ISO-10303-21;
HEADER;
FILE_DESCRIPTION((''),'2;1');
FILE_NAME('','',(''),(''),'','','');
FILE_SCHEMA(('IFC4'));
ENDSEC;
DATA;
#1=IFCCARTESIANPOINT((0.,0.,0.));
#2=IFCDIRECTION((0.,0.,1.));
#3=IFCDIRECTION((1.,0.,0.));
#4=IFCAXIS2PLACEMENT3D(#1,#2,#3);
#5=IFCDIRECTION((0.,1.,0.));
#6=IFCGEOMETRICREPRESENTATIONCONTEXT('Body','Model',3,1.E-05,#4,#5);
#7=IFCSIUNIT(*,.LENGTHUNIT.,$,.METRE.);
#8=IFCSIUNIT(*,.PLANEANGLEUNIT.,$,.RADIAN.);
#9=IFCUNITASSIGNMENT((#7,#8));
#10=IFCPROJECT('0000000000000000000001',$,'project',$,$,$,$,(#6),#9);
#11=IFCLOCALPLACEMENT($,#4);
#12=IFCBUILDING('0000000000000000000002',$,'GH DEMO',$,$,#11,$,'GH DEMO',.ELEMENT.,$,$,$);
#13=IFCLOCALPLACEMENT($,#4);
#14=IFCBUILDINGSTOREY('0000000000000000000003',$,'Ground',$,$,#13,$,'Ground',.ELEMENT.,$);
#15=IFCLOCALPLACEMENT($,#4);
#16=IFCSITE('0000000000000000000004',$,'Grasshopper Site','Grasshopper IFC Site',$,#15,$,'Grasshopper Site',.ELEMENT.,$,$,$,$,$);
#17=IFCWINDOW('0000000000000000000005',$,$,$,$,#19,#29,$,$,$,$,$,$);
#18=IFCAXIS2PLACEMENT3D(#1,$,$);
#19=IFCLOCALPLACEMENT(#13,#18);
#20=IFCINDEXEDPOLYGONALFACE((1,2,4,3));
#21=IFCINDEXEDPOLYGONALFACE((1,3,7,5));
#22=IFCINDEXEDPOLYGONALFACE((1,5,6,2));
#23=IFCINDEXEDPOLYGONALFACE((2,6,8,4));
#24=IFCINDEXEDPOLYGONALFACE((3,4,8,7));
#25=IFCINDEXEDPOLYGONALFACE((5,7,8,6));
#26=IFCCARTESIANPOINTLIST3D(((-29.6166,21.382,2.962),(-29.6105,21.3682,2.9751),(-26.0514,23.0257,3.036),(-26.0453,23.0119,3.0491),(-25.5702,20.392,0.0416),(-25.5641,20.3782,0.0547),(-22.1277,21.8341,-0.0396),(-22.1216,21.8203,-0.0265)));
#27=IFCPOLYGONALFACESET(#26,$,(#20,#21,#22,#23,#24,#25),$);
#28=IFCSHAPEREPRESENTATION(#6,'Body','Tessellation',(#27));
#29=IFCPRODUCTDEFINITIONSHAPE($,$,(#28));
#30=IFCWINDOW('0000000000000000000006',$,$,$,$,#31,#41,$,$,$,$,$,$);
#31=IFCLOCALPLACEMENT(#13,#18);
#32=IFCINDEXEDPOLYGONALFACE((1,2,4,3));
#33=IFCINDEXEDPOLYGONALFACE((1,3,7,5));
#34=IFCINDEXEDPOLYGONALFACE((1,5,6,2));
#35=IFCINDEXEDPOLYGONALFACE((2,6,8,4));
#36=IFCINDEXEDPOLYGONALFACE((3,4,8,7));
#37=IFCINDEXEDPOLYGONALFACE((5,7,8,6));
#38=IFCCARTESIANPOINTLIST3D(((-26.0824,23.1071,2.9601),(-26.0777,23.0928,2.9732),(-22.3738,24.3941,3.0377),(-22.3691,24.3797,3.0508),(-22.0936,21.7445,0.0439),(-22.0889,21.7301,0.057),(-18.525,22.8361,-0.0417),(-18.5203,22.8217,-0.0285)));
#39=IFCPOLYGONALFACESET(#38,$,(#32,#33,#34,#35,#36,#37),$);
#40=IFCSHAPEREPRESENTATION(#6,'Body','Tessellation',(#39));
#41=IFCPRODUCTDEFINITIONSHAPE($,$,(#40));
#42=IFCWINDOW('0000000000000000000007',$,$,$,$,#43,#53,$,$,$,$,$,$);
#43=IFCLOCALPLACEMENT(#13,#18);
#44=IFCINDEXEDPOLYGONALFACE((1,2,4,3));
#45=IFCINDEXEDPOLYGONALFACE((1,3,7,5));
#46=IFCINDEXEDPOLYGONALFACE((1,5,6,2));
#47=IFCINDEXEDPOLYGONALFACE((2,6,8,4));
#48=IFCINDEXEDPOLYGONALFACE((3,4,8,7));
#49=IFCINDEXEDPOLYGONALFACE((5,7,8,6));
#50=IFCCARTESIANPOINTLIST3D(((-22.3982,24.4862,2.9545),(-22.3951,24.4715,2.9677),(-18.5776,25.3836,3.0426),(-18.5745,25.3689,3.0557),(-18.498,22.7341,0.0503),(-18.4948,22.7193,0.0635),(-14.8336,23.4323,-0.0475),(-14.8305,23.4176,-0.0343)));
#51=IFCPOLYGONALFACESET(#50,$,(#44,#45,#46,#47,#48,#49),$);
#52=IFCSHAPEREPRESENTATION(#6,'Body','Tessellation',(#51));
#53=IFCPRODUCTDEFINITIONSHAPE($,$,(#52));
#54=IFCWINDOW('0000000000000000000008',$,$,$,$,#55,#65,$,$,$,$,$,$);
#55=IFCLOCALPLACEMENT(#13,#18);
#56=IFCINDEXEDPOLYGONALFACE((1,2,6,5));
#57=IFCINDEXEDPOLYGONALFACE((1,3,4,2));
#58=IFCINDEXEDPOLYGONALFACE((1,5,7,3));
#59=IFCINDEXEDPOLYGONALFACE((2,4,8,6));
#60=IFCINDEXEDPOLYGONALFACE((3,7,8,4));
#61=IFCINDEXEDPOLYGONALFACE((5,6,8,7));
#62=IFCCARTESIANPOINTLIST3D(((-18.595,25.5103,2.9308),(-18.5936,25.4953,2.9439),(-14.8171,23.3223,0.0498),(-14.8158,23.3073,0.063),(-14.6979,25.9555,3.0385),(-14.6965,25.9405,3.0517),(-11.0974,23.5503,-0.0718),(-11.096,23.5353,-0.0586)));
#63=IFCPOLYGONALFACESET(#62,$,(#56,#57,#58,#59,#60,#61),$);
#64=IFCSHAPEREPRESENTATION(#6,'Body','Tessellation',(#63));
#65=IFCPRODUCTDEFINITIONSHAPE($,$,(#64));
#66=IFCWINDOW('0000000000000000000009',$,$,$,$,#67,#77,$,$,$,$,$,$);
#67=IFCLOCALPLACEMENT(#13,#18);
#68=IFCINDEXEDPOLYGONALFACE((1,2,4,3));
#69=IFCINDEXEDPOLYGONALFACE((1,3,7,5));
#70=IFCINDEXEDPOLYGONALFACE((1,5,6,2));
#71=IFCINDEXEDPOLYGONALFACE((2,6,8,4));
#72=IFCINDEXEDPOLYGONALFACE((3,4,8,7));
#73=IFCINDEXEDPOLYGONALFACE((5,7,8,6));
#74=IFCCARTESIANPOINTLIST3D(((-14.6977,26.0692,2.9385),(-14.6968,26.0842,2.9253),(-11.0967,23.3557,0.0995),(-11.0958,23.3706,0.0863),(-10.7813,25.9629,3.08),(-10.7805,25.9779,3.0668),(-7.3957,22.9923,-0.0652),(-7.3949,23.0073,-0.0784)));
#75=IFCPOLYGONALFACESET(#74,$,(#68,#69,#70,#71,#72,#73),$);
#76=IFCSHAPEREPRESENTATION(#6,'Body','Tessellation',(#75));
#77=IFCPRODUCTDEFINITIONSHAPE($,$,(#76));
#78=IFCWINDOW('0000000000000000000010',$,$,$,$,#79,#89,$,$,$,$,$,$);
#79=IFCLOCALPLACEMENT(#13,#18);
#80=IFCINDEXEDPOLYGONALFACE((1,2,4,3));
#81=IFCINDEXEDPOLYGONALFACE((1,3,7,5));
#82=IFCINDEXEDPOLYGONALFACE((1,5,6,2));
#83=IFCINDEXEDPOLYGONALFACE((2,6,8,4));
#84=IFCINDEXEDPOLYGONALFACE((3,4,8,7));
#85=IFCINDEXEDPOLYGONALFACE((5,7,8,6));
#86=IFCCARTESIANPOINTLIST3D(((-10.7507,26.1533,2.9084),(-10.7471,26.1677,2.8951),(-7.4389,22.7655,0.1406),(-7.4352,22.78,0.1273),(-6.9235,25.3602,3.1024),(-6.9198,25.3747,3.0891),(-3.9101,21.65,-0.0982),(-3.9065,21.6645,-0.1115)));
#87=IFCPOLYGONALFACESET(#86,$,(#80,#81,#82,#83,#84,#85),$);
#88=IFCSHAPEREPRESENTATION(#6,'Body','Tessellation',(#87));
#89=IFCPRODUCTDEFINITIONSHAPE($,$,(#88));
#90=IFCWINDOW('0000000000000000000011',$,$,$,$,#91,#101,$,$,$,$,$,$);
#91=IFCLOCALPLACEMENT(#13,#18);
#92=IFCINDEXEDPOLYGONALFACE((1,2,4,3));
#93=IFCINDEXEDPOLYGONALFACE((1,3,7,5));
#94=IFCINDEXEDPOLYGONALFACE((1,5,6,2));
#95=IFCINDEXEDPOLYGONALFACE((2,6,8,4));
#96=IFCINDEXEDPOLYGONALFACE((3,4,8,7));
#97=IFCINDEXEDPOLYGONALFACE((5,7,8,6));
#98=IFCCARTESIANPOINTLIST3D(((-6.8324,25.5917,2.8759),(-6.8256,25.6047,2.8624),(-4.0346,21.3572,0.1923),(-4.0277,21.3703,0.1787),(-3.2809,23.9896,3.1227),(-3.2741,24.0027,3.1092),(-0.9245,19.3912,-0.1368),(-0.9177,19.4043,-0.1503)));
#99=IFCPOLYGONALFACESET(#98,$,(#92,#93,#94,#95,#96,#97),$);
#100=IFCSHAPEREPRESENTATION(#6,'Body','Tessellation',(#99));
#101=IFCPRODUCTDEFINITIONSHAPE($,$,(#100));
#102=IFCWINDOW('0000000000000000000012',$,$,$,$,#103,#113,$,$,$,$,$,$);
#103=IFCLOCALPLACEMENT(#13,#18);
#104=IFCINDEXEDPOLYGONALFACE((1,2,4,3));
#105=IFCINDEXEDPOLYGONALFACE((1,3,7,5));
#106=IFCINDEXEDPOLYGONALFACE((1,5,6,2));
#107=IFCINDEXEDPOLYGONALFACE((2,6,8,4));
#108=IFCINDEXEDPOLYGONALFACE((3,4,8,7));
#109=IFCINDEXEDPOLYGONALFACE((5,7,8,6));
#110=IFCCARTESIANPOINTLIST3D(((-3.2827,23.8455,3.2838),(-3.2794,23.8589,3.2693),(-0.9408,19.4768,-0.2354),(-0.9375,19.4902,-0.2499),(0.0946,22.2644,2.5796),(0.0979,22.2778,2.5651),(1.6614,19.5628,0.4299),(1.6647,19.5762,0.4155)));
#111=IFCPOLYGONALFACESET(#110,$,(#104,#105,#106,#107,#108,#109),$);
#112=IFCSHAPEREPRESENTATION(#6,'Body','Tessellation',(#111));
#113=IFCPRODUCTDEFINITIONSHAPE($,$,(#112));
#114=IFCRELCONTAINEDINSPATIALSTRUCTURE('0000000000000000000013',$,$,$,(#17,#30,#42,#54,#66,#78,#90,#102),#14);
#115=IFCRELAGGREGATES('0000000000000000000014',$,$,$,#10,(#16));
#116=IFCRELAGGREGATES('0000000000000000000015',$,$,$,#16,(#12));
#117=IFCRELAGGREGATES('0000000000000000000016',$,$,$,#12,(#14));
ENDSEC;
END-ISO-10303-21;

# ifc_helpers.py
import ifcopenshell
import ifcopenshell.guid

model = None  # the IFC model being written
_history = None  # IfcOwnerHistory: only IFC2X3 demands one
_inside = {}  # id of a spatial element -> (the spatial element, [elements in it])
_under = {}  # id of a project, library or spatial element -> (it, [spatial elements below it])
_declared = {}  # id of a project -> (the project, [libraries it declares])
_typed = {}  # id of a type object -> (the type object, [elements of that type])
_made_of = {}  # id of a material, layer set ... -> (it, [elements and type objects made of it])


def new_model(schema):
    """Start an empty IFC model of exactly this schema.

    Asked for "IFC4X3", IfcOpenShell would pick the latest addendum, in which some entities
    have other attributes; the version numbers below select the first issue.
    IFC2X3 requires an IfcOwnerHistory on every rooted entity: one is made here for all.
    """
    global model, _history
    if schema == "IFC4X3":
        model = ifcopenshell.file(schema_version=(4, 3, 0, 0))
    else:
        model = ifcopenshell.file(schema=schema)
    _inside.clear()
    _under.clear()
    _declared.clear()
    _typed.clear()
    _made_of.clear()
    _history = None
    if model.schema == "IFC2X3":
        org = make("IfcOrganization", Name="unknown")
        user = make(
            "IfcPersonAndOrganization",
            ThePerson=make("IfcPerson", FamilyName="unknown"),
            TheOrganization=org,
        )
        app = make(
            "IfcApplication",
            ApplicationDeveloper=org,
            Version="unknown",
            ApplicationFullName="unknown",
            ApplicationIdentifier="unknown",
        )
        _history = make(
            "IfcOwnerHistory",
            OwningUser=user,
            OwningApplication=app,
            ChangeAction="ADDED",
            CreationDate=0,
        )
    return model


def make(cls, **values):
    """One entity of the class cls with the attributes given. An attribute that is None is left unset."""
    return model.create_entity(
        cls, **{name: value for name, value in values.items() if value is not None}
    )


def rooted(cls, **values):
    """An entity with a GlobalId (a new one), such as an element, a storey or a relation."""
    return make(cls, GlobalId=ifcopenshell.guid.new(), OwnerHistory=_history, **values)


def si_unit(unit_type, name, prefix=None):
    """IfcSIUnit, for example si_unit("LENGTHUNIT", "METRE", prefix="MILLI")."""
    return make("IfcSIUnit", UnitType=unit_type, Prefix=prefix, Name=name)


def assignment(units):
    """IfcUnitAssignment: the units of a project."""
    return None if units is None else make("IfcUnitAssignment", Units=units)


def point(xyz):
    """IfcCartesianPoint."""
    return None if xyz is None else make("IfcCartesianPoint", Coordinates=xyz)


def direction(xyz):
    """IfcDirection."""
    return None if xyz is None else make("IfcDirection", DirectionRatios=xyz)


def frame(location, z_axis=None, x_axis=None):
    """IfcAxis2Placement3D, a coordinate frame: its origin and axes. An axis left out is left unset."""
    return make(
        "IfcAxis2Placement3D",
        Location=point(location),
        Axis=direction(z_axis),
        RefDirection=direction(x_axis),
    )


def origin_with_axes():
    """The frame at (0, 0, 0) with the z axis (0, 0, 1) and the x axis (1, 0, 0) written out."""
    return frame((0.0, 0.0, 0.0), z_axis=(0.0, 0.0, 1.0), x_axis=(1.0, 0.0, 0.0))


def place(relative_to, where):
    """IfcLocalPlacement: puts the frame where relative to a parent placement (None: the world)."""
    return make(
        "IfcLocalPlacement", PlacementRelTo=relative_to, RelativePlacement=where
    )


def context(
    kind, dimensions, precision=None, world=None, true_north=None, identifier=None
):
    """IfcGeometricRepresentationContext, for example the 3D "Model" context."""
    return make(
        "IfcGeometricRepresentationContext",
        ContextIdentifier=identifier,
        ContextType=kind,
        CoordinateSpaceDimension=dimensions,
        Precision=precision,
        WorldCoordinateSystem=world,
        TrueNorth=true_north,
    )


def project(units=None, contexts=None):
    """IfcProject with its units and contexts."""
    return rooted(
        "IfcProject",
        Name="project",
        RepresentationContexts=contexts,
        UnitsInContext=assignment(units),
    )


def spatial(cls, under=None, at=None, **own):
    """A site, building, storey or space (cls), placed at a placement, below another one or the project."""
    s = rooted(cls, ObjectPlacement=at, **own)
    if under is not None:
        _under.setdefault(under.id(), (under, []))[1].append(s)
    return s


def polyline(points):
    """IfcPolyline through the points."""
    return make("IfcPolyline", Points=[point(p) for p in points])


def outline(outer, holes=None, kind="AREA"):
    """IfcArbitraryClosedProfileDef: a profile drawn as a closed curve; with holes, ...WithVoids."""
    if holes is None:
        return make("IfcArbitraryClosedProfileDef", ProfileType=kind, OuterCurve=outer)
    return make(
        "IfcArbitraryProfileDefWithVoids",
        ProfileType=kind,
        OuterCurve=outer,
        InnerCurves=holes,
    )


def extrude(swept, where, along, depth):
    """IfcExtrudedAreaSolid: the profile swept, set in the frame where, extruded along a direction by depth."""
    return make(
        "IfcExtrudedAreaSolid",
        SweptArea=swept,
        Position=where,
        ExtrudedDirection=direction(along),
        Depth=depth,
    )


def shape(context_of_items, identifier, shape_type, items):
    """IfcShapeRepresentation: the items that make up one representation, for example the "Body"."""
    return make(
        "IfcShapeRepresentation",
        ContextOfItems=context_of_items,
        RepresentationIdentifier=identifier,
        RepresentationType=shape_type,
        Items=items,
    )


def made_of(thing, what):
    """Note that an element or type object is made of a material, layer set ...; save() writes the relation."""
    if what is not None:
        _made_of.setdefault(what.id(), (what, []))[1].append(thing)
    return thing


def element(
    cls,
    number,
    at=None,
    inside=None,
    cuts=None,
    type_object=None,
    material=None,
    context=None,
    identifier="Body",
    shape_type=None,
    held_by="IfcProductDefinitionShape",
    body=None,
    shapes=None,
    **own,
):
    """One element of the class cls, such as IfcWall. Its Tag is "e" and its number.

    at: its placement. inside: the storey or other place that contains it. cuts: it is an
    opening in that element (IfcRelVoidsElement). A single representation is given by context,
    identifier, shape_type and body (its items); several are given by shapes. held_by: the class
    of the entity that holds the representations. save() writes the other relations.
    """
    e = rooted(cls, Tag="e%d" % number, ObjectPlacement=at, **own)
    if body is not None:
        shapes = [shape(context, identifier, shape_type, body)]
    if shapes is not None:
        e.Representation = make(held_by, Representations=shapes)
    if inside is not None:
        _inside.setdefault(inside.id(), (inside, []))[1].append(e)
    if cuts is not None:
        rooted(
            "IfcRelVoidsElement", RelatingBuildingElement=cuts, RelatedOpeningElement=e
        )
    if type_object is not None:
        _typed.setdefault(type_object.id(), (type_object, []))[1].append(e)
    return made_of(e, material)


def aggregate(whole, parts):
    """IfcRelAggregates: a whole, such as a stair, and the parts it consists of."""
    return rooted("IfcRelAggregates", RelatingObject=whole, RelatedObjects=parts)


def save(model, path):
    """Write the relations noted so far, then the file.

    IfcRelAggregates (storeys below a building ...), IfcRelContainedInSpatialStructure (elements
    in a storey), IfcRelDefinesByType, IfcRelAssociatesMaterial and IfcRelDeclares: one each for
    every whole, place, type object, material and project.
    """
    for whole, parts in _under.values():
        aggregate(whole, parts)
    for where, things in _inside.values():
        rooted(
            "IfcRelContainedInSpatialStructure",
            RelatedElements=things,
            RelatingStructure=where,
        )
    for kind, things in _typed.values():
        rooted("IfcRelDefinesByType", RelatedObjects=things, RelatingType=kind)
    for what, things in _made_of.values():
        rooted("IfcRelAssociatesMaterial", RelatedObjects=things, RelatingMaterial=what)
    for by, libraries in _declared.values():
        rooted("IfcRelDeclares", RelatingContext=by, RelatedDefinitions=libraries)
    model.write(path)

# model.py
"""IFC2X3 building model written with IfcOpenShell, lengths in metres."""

from ifc_helpers import new_model, si_unit, direction, frame, origin_with_axes, place, context, project, spatial, polyline, outline, extrude, element, save


model = new_model("IFC2X3")

# Units and contexts
model_context = context("Model", 3, precision=1e-05, world=origin_with_axes(), true_north=direction((0.0, 1.0, 0.0)), identifier="Body")
ifc_project = project(units=[si_unit("LENGTHUNIT", "METRE"), si_unit("PLANEANGLEUNIT", "RADIAN")], contexts=[model_context])

# Site, building, storey
site_placement = place(None, origin_with_axes())
site = spatial("IfcSite", under=ifc_project, at=site_placement, Name="Grasshopper Site", Description="Grasshopper IFC Site", LongName="Grasshopper Site", CompositionType="ELEMENT")
building_placement = place(None, origin_with_axes())
building = spatial("IfcBuilding", under=site, at=building_placement, Name="GH DEMO", LongName="GH DEMO", CompositionType="ELEMENT")
storey_placement = place(None, origin_with_axes())
storey = spatial("IfcBuildingStorey", under=building, at=storey_placement, Name="Ground", LongName="Ground", CompositionType="ELEMENT")

# Windows
window_1_placement = place(None, origin_with_axes())
element("IfcWindow", 1, at=window_1_placement, inside=storey, context=model_context, shape_type="SweptSolid", body=[
    extrude(outline(polyline([(0.0, 0.0), (5.0874, 0.0), (2.6142, 3.0496), (-2.5041, 2.7689), (0.0, 0.0)])), frame((-25.5702, 20.392, 0.0416), z_axis=(-0.304678, 0.690364, -0.656178), x_axis=(-0.795367, 0.194596, 0.574041)), (0.0, 0.0, -1.0), 0.02),
])
window_2_placement = place(None, origin_with_axes())
element("IfcWindow", 2, at=window_2_placement, inside=storey, context=model_context, shape_type="SweptSolid", body=[
    extrude(outline(polyline([(0.0, 0.0), (5.1256, 0.0), (2.6258, 3.0277), (-2.5356, 2.7394), (0.0, 0.0)])), frame((-22.0936, 21.7445, 0.0439), z_axis=(-0.235014, 0.716849, -0.656427), x_axis=(-0.77822, 0.265853, 0.568942)), (0.0, 0.0, -1.0), 0.02),
])
window_3_placement = place(None, origin_with_axes())
element("IfcWindow", 3, at=window_3_placement, inside=storey, context=model_context, shape_type="SweptSolid", body=[
    extrude(outline(polyline([(0.0, 0.0), (5.1688, 0.0), (2.6395, 3.0021), (-2.5833, 2.6928), (0.0, 0.0)])), frame((-18.498, 22.7341, 0.0503), z_axis=(-0.158012, 0.737178, -0.656963), x_axis=(-0.75458, 0.338988, 0.561869)), (0.0, 0.0, -1.0), 0.02),
])
window_4_placement = place(None, origin_with_axes())
element("IfcWindow", 4, at=window_4_placement, inside=storey, context=model_context, shape_type="SweptSolid", body=[
    extrude(outline(polyline([(0.0, 0.0), (5.2306, 0.0), (2.6615, 2.9659), (-2.6582, 2.6148), (0.0, 0.0)])), frame((-14.8158, 23.3073, 0.063), z_axis=(-0.067491, 0.749936, -0.658059), x_axis=(-0.722258, 0.418306, 0.550784)), (0.0, 0.0, 1.0), 0.02),
])
window_5_placement = place(None, origin_with_axes())
element("IfcWindow", 5, at=window_5_placement, inside=storey, context=model_context, shape_type="SweptSolid", body=[
    extrude(outline(polyline([(0.0, 0.0), (5.3283, 0.0), (2.7028, 2.9113), (-2.774, 2.4822), (0.0, 0.0)])), frame((-11.0958, 23.3706, 0.0863), z_axis=(0.044215, 0.749613, -0.660398), x_axis=(-0.67583, 0.50927, 0.53282)), (0.0, 0.0, -1.0), 0.02),
])
window_6_placement = place(None, origin_with_axes())
element("IfcWindow", 6, at=window_6_placement, inside=storey, context=model_context, shape_type="SweptSolid", body=[
    extrude(outline(polyline([(0.0, 0.0), (5.4869, 0.0), (2.785, 2.8309), (-2.9391, 2.2616), (0.0, 0.0)])), frame((-7.4352, 22.78, 0.1273), z_axis=(0.183614, 0.723324, -0.665649), x_axis=(-0.603591, 0.617433, 0.504434)), (0.0, 0.0, -1.0), 0.02),
])
window_7_placement = place(None, origin_with_axes())
element("IfcWindow", 7, at=window_7_placement, inside=storey, context=model_context, shape_type="SweptSolid", body=[
    extrude(outline(polyline([(0.0, 0.0), (5.7411, 0.0), (2.9441, 2.7235), (-3.1195, 1.9785), (0.0, 0.0)])), frame((-4.0277, 21.3703, 0.1787), z_axis=(0.34181, 0.653715, -0.675146), x_axis=(-0.487331, 0.737572, 0.467435)), (0.0, 0.0, -1.0), 0.02),
])
window_8_placement = place(None, origin_with_axes())
element("IfcWindow", 8, at=window_8_placement, inside=storey, context=model_context, shape_type="SweptSolid", body=[
    extrude(outline(polyline([(0.0, 0.0), (6.0791, 0.0), (3.234, 2.5116), (-0.5555, 2.6292), (0.0, 0.0)])), frame((-0.9375, 19.4902, -0.2499), z_axis=(0.162925, 0.670437, -0.723858), x_axis=(-0.385242, 0.718651, 0.578904)), (0.0, 0.0, -1.0), 0.02),
])

save(model, "model.ifc")
